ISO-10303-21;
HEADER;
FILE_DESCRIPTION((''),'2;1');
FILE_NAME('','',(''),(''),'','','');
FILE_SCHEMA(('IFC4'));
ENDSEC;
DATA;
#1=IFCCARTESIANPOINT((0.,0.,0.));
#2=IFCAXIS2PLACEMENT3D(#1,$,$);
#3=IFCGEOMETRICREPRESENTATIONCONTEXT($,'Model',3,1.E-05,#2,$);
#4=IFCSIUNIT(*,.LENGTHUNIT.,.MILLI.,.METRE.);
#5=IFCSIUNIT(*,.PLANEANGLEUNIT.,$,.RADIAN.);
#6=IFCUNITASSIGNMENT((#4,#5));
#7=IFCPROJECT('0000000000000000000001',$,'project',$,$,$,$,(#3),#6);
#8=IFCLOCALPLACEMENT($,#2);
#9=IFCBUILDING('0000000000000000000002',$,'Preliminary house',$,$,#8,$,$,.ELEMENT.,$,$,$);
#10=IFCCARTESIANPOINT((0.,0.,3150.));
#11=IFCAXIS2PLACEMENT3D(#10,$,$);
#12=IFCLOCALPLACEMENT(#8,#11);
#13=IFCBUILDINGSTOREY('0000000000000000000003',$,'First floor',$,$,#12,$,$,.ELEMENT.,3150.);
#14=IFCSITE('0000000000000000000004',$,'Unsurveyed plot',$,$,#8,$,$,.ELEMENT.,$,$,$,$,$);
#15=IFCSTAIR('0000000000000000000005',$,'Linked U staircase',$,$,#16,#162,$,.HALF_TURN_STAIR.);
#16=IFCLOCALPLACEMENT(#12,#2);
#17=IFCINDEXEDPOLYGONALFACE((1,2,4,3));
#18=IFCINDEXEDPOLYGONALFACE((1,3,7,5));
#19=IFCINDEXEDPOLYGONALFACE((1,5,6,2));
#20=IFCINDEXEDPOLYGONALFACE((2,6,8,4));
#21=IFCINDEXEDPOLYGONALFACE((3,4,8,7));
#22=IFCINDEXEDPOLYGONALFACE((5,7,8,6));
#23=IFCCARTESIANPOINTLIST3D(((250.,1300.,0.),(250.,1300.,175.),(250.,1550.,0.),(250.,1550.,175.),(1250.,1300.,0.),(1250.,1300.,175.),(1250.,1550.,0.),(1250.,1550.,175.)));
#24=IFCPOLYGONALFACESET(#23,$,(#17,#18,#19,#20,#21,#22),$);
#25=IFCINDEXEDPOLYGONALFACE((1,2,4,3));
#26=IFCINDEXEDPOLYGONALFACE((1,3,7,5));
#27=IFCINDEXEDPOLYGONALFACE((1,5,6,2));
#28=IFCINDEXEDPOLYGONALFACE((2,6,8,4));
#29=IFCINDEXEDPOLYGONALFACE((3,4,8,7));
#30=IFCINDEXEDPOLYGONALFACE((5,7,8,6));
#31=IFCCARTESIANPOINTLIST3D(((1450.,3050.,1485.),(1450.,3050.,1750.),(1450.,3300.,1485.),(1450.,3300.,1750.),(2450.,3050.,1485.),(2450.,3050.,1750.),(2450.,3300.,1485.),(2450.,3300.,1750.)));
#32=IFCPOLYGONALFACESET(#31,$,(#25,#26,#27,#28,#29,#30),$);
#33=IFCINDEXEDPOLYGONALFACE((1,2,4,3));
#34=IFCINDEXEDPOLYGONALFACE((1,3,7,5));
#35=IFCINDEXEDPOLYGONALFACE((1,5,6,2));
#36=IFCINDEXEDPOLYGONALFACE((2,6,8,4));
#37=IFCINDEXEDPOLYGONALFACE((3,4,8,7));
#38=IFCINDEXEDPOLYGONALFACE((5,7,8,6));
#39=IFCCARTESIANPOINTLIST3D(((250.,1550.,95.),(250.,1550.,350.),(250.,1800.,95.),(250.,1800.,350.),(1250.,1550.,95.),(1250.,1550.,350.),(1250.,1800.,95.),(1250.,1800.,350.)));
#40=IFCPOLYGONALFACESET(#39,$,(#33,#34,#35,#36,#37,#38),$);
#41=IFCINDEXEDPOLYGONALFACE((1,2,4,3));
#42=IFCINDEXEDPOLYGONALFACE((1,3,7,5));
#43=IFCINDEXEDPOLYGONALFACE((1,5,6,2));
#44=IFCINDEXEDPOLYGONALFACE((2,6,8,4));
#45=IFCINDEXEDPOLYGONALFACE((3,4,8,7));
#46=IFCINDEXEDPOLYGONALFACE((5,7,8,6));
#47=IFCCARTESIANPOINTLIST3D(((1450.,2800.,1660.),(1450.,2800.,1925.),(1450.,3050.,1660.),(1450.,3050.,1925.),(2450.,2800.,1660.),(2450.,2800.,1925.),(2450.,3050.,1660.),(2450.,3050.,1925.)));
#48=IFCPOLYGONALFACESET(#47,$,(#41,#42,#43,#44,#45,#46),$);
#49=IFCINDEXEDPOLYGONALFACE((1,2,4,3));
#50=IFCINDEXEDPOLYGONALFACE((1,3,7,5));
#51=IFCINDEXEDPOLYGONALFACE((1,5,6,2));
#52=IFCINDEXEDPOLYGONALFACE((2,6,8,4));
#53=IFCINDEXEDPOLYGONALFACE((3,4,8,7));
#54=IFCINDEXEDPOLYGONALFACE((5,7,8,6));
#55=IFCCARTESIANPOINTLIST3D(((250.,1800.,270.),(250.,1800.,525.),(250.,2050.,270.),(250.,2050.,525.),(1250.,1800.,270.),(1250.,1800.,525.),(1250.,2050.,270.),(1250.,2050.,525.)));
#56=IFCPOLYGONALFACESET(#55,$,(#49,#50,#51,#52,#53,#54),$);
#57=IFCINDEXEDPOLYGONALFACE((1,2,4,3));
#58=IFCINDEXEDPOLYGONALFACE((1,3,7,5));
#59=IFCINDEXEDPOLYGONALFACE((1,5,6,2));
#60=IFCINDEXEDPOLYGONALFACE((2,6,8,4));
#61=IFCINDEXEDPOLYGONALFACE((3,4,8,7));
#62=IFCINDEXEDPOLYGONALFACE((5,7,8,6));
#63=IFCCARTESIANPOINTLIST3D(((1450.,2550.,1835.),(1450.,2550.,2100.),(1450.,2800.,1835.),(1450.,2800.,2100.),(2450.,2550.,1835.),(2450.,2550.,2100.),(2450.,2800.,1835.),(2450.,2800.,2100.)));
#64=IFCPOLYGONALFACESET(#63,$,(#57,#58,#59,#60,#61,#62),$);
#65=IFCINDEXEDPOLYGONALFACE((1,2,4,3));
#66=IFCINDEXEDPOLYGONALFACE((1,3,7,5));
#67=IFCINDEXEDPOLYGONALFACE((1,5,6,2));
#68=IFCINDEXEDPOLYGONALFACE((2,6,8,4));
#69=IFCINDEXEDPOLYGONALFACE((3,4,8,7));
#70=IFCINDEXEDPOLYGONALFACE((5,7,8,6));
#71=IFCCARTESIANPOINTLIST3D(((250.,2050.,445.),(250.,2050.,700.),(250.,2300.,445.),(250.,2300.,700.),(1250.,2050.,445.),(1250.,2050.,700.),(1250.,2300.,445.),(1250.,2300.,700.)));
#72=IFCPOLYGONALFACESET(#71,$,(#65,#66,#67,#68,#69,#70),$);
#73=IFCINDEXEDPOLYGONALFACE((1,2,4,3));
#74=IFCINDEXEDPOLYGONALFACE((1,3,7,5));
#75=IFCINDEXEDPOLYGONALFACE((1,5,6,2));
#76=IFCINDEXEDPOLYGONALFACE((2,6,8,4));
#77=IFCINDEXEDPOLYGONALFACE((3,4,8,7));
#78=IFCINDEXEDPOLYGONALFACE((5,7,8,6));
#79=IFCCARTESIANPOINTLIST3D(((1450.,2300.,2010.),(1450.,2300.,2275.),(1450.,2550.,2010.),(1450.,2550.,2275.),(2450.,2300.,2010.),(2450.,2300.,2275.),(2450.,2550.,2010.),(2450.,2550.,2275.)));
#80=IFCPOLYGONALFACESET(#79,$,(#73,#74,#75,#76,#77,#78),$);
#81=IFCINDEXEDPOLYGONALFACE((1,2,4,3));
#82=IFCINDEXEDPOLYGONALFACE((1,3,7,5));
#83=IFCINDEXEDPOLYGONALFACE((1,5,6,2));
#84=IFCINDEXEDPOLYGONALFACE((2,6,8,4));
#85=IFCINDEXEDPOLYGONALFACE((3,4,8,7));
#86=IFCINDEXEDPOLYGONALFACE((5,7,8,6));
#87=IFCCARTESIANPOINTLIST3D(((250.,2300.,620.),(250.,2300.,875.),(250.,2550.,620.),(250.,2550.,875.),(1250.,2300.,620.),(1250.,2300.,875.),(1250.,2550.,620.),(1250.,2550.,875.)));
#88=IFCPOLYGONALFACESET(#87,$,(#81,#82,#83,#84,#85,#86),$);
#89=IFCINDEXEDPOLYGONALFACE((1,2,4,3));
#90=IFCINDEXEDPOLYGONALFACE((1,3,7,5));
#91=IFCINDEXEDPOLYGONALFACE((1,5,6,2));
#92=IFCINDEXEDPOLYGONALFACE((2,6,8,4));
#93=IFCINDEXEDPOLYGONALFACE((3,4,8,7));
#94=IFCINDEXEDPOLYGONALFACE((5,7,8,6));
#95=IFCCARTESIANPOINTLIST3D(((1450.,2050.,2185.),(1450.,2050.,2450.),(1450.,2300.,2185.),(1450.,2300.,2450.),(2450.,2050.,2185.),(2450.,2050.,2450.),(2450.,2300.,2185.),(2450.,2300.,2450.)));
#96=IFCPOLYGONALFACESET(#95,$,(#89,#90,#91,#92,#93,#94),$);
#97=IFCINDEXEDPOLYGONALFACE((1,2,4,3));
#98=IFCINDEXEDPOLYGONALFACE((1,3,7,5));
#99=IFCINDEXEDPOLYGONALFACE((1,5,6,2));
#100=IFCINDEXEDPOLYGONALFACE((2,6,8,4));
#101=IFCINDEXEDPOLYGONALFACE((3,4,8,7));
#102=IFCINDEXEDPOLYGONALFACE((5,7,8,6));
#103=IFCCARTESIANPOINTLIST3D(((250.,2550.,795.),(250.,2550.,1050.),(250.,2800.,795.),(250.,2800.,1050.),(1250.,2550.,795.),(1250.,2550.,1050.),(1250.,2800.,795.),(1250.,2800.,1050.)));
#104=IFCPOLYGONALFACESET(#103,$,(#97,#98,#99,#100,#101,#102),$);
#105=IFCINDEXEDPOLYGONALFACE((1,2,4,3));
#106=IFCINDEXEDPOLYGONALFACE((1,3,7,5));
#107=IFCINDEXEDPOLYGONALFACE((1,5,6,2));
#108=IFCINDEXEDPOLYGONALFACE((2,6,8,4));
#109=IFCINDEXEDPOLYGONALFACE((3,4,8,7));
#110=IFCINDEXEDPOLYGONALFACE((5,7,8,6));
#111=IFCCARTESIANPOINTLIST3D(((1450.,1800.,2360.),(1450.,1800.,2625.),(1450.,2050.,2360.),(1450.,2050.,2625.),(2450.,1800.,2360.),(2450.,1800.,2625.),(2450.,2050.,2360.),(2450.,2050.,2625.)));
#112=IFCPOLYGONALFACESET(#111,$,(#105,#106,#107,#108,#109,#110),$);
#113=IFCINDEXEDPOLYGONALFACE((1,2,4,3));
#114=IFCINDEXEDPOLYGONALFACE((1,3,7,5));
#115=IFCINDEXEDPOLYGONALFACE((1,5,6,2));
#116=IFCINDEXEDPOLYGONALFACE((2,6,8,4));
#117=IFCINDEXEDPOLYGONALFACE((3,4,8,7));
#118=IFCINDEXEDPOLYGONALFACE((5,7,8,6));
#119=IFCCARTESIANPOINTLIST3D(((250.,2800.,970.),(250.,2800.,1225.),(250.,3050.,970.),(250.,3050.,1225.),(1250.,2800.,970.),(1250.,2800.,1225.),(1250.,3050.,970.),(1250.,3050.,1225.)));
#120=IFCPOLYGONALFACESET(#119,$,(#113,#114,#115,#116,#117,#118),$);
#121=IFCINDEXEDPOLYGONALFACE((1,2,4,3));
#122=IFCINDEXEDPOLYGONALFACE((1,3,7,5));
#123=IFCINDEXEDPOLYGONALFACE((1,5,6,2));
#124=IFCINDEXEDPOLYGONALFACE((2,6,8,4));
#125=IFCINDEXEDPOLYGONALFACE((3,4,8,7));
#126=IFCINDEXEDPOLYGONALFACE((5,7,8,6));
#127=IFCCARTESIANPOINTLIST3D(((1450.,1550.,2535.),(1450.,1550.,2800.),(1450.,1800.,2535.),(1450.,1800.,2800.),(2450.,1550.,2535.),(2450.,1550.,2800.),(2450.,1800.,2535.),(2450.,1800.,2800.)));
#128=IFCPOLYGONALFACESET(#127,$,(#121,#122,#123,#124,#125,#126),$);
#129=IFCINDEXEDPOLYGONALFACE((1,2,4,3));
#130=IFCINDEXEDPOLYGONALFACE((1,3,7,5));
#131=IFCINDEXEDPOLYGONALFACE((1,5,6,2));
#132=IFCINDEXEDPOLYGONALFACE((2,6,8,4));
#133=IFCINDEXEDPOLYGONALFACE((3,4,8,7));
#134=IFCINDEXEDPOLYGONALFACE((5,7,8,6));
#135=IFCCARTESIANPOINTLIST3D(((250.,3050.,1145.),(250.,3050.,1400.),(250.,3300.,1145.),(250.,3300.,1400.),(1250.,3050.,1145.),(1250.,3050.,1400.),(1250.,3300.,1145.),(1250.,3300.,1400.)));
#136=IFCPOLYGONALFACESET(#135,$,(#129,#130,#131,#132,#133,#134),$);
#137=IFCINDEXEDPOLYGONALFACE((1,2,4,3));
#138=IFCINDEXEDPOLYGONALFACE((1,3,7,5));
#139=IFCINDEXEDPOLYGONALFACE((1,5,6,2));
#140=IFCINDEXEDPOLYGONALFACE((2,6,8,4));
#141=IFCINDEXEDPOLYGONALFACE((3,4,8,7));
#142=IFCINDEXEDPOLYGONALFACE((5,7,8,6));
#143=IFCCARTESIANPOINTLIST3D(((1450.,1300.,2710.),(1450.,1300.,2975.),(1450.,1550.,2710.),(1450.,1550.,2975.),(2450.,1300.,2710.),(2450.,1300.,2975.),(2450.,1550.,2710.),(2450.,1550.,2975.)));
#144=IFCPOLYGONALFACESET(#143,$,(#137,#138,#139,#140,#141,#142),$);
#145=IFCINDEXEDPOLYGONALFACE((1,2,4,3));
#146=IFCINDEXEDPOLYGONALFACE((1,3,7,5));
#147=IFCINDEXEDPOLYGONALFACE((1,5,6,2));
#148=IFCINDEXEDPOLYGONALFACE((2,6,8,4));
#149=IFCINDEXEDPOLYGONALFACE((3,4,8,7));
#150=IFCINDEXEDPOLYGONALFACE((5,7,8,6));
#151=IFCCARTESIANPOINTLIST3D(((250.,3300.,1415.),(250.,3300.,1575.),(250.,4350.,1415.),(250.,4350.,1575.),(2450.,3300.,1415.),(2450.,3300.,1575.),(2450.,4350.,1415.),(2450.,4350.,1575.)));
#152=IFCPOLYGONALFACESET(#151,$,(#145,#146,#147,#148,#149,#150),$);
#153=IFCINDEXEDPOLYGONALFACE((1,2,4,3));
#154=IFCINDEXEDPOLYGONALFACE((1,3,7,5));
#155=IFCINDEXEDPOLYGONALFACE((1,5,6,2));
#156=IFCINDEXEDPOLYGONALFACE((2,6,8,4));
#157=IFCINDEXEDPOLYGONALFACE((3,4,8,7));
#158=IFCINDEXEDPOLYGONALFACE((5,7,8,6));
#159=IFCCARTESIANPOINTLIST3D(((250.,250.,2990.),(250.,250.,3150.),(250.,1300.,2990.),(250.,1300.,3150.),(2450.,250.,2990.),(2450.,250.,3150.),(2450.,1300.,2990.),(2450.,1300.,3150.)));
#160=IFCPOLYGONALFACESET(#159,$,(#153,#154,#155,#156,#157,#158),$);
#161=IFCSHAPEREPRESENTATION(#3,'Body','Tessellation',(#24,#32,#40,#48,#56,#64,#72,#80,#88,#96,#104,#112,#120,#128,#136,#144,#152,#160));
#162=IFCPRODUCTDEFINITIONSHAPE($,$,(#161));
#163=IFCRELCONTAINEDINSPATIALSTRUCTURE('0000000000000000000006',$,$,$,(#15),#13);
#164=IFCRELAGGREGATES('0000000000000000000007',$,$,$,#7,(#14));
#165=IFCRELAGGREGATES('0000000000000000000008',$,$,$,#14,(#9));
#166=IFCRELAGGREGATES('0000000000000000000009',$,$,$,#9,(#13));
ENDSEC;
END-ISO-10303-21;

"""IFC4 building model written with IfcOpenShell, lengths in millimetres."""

from ifc_helpers import new_model, si_unit, frame, origin, place, context, project, spatial, polyline, outline, extrude, element, save


model = new_model("IFC4")

# Units and contexts
model_context = context("Model", 3, precision=1e-05, world=origin())
ifc_project = project(units=[si_unit("LENGTHUNIT", "METRE", prefix="MILLI"), si_unit("PLANEANGLEUNIT", "RADIAN")], contexts=[model_context])

# Site, building, storey
placement_1 = place(None, origin())
site = spatial("IfcSite", under=ifc_project, at=placement_1, Name="Unsurveyed plot", CompositionType="ELEMENT")
building = spatial("IfcBuilding", under=site, at=placement_1, Name="Preliminary house", CompositionType="ELEMENT")
placement_2 = place(placement_1, frame((0.0, 0.0, 3150.0)))
storey = spatial("IfcBuildingStorey", under=building, at=placement_2, Name="First floor", CompositionType="ELEMENT", Elevation=3150.0)

# Stair
element("IfcStair", 1, at=placement_2, inside=storey, Name="Linked U staircase", PredefinedType="HALF_TURN_STAIR", context=model_context, shape_type="SweptSolid", body=[
    extrude(outline(polyline([(1250.0, 1300.0), (1250.0, 1550.0), (250.0, 1550.0), (250.0, 1300.0), (1250.0, 1300.0)])), origin(), (0.0, 0.0, 1.0), 175.0),
    extrude(outline(polyline([(2450.0, 3050.0), (2450.0, 3300.0), (1450.0, 3300.0), (1450.0, 3050.0), (2450.0, 3050.0)])), frame((0.0, 0.0, 1485.0)), (0.0, 0.0, 1.0), 265.0),
    extrude(outline(polyline([(1250.0, 1550.0), (1250.0, 1800.0), (250.0, 1800.0), (250.0, 1550.0), (1250.0, 1550.0)])), frame((0.0, 0.0, 95.0)), (0.0, 0.0, 1.0), 255.0),
    extrude(outline(polyline([(2450.0, 2800.0), (2450.0, 3050.0), (1450.0, 3050.0), (1450.0, 2800.0), (2450.0, 2800.0)])), frame((0.0, 0.0, 1660.0)), (0.0, 0.0, 1.0), 265.0),
    extrude(outline(polyline([(1250.0, 1800.0), (1250.0, 2050.0), (250.0, 2050.0), (250.0, 1800.0), (1250.0, 1800.0)])), frame((0.0, 0.0, 270.0)), (0.0, 0.0, 1.0), 255.0),
    extrude(outline(polyline([(2450.0, 2550.0), (2450.0, 2800.0), (1450.0, 2800.0), (1450.0, 2550.0), (2450.0, 2550.0)])), frame((0.0, 0.0, 1835.0)), (0.0, 0.0, 1.0), 265.0),
    extrude(outline(polyline([(1250.0, 2050.0), (1250.0, 2300.0), (250.0, 2300.0), (250.0, 2050.0), (1250.0, 2050.0)])), frame((0.0, 0.0, 445.0)), (0.0, 0.0, 1.0), 255.0),
    extrude(outline(polyline([(2450.0, 2300.0), (2450.0, 2550.0), (1450.0, 2550.0), (1450.0, 2300.0), (2450.0, 2300.0)])), frame((0.0, 0.0, 2010.0)), (0.0, 0.0, 1.0), 265.0),
    extrude(outline(polyline([(1250.0, 2300.0), (1250.0, 2550.0), (250.0, 2550.0), (250.0, 2300.0), (1250.0, 2300.0)])), frame((0.0, 0.0, 620.0)), (0.0, 0.0, 1.0), 255.0),
    extrude(outline(polyline([(2450.0, 2050.0), (2450.0, 2300.0), (1450.0, 2300.0), (1450.0, 2050.0), (2450.0, 2050.0)])), frame((0.0, 0.0, 2185.0)), (0.0, 0.0, 1.0), 265.0),
    extrude(outline(polyline([(1250.0, 2550.0), (1250.0, 2800.0), (250.0, 2800.0), (250.0, 2550.0), (1250.0, 2550.0)])), frame((0.0, 0.0, 795.0)), (0.0, 0.0, 1.0), 255.0),
    extrude(outline(polyline([(2450.0, 1800.0), (2450.0, 2050.0), (1450.0, 2050.0), (1450.0, 1800.0), (2450.0, 1800.0)])), frame((0.0, 0.0, 2360.0)), (0.0, 0.0, 1.0), 265.0),
    extrude(outline(polyline([(1250.0, 2800.0), (1250.0, 3050.0), (250.0, 3050.0), (250.0, 2800.0), (1250.0, 2800.0)])), frame((0.0, 0.0, 970.0)), (0.0, 0.0, 1.0), 255.0),
    extrude(outline(polyline([(2450.0, 1550.0), (2450.0, 1800.0), (1450.0, 1800.0), (1450.0, 1550.0), (2450.0, 1550.0)])), frame((0.0, 0.0, 2535.0)), (0.0, 0.0, 1.0), 265.0),
    extrude(outline(polyline([(1250.0, 3050.0), (1250.0, 3300.0), (250.0, 3300.0), (250.0, 3050.0), (1250.0, 3050.0)])), frame((0.0, 0.0, 1145.0)), (0.0, 0.0, 1.0), 255.0),
    extrude(outline(polyline([(2450.0, 1300.0), (2450.0, 1550.0), (1450.0, 1550.0), (1450.0, 1300.0), (2450.0, 1300.0)])), frame((0.0, 0.0, 2710.0)), (0.0, 0.0, 1.0), 265.0),
    extrude(outline(polyline([(2450.0, 3300.0), (2450.0, 4350.0), (250.0, 4350.0), (250.0, 3300.0), (2450.0, 3300.0)])), frame((0.0, 0.0, 1415.0)), (0.0, 0.0, 1.0), 160.0),
    extrude(outline(polyline([(2450.0, 250.0), (2450.0, 1300.0), (250.0, 1300.0), (250.0, 250.0), (2450.0, 250.0)])), frame((0.0, 0.0, 2990.0)), (0.0, 0.0, 1.0), 160.0),
])

save(model, "model.ifc")
